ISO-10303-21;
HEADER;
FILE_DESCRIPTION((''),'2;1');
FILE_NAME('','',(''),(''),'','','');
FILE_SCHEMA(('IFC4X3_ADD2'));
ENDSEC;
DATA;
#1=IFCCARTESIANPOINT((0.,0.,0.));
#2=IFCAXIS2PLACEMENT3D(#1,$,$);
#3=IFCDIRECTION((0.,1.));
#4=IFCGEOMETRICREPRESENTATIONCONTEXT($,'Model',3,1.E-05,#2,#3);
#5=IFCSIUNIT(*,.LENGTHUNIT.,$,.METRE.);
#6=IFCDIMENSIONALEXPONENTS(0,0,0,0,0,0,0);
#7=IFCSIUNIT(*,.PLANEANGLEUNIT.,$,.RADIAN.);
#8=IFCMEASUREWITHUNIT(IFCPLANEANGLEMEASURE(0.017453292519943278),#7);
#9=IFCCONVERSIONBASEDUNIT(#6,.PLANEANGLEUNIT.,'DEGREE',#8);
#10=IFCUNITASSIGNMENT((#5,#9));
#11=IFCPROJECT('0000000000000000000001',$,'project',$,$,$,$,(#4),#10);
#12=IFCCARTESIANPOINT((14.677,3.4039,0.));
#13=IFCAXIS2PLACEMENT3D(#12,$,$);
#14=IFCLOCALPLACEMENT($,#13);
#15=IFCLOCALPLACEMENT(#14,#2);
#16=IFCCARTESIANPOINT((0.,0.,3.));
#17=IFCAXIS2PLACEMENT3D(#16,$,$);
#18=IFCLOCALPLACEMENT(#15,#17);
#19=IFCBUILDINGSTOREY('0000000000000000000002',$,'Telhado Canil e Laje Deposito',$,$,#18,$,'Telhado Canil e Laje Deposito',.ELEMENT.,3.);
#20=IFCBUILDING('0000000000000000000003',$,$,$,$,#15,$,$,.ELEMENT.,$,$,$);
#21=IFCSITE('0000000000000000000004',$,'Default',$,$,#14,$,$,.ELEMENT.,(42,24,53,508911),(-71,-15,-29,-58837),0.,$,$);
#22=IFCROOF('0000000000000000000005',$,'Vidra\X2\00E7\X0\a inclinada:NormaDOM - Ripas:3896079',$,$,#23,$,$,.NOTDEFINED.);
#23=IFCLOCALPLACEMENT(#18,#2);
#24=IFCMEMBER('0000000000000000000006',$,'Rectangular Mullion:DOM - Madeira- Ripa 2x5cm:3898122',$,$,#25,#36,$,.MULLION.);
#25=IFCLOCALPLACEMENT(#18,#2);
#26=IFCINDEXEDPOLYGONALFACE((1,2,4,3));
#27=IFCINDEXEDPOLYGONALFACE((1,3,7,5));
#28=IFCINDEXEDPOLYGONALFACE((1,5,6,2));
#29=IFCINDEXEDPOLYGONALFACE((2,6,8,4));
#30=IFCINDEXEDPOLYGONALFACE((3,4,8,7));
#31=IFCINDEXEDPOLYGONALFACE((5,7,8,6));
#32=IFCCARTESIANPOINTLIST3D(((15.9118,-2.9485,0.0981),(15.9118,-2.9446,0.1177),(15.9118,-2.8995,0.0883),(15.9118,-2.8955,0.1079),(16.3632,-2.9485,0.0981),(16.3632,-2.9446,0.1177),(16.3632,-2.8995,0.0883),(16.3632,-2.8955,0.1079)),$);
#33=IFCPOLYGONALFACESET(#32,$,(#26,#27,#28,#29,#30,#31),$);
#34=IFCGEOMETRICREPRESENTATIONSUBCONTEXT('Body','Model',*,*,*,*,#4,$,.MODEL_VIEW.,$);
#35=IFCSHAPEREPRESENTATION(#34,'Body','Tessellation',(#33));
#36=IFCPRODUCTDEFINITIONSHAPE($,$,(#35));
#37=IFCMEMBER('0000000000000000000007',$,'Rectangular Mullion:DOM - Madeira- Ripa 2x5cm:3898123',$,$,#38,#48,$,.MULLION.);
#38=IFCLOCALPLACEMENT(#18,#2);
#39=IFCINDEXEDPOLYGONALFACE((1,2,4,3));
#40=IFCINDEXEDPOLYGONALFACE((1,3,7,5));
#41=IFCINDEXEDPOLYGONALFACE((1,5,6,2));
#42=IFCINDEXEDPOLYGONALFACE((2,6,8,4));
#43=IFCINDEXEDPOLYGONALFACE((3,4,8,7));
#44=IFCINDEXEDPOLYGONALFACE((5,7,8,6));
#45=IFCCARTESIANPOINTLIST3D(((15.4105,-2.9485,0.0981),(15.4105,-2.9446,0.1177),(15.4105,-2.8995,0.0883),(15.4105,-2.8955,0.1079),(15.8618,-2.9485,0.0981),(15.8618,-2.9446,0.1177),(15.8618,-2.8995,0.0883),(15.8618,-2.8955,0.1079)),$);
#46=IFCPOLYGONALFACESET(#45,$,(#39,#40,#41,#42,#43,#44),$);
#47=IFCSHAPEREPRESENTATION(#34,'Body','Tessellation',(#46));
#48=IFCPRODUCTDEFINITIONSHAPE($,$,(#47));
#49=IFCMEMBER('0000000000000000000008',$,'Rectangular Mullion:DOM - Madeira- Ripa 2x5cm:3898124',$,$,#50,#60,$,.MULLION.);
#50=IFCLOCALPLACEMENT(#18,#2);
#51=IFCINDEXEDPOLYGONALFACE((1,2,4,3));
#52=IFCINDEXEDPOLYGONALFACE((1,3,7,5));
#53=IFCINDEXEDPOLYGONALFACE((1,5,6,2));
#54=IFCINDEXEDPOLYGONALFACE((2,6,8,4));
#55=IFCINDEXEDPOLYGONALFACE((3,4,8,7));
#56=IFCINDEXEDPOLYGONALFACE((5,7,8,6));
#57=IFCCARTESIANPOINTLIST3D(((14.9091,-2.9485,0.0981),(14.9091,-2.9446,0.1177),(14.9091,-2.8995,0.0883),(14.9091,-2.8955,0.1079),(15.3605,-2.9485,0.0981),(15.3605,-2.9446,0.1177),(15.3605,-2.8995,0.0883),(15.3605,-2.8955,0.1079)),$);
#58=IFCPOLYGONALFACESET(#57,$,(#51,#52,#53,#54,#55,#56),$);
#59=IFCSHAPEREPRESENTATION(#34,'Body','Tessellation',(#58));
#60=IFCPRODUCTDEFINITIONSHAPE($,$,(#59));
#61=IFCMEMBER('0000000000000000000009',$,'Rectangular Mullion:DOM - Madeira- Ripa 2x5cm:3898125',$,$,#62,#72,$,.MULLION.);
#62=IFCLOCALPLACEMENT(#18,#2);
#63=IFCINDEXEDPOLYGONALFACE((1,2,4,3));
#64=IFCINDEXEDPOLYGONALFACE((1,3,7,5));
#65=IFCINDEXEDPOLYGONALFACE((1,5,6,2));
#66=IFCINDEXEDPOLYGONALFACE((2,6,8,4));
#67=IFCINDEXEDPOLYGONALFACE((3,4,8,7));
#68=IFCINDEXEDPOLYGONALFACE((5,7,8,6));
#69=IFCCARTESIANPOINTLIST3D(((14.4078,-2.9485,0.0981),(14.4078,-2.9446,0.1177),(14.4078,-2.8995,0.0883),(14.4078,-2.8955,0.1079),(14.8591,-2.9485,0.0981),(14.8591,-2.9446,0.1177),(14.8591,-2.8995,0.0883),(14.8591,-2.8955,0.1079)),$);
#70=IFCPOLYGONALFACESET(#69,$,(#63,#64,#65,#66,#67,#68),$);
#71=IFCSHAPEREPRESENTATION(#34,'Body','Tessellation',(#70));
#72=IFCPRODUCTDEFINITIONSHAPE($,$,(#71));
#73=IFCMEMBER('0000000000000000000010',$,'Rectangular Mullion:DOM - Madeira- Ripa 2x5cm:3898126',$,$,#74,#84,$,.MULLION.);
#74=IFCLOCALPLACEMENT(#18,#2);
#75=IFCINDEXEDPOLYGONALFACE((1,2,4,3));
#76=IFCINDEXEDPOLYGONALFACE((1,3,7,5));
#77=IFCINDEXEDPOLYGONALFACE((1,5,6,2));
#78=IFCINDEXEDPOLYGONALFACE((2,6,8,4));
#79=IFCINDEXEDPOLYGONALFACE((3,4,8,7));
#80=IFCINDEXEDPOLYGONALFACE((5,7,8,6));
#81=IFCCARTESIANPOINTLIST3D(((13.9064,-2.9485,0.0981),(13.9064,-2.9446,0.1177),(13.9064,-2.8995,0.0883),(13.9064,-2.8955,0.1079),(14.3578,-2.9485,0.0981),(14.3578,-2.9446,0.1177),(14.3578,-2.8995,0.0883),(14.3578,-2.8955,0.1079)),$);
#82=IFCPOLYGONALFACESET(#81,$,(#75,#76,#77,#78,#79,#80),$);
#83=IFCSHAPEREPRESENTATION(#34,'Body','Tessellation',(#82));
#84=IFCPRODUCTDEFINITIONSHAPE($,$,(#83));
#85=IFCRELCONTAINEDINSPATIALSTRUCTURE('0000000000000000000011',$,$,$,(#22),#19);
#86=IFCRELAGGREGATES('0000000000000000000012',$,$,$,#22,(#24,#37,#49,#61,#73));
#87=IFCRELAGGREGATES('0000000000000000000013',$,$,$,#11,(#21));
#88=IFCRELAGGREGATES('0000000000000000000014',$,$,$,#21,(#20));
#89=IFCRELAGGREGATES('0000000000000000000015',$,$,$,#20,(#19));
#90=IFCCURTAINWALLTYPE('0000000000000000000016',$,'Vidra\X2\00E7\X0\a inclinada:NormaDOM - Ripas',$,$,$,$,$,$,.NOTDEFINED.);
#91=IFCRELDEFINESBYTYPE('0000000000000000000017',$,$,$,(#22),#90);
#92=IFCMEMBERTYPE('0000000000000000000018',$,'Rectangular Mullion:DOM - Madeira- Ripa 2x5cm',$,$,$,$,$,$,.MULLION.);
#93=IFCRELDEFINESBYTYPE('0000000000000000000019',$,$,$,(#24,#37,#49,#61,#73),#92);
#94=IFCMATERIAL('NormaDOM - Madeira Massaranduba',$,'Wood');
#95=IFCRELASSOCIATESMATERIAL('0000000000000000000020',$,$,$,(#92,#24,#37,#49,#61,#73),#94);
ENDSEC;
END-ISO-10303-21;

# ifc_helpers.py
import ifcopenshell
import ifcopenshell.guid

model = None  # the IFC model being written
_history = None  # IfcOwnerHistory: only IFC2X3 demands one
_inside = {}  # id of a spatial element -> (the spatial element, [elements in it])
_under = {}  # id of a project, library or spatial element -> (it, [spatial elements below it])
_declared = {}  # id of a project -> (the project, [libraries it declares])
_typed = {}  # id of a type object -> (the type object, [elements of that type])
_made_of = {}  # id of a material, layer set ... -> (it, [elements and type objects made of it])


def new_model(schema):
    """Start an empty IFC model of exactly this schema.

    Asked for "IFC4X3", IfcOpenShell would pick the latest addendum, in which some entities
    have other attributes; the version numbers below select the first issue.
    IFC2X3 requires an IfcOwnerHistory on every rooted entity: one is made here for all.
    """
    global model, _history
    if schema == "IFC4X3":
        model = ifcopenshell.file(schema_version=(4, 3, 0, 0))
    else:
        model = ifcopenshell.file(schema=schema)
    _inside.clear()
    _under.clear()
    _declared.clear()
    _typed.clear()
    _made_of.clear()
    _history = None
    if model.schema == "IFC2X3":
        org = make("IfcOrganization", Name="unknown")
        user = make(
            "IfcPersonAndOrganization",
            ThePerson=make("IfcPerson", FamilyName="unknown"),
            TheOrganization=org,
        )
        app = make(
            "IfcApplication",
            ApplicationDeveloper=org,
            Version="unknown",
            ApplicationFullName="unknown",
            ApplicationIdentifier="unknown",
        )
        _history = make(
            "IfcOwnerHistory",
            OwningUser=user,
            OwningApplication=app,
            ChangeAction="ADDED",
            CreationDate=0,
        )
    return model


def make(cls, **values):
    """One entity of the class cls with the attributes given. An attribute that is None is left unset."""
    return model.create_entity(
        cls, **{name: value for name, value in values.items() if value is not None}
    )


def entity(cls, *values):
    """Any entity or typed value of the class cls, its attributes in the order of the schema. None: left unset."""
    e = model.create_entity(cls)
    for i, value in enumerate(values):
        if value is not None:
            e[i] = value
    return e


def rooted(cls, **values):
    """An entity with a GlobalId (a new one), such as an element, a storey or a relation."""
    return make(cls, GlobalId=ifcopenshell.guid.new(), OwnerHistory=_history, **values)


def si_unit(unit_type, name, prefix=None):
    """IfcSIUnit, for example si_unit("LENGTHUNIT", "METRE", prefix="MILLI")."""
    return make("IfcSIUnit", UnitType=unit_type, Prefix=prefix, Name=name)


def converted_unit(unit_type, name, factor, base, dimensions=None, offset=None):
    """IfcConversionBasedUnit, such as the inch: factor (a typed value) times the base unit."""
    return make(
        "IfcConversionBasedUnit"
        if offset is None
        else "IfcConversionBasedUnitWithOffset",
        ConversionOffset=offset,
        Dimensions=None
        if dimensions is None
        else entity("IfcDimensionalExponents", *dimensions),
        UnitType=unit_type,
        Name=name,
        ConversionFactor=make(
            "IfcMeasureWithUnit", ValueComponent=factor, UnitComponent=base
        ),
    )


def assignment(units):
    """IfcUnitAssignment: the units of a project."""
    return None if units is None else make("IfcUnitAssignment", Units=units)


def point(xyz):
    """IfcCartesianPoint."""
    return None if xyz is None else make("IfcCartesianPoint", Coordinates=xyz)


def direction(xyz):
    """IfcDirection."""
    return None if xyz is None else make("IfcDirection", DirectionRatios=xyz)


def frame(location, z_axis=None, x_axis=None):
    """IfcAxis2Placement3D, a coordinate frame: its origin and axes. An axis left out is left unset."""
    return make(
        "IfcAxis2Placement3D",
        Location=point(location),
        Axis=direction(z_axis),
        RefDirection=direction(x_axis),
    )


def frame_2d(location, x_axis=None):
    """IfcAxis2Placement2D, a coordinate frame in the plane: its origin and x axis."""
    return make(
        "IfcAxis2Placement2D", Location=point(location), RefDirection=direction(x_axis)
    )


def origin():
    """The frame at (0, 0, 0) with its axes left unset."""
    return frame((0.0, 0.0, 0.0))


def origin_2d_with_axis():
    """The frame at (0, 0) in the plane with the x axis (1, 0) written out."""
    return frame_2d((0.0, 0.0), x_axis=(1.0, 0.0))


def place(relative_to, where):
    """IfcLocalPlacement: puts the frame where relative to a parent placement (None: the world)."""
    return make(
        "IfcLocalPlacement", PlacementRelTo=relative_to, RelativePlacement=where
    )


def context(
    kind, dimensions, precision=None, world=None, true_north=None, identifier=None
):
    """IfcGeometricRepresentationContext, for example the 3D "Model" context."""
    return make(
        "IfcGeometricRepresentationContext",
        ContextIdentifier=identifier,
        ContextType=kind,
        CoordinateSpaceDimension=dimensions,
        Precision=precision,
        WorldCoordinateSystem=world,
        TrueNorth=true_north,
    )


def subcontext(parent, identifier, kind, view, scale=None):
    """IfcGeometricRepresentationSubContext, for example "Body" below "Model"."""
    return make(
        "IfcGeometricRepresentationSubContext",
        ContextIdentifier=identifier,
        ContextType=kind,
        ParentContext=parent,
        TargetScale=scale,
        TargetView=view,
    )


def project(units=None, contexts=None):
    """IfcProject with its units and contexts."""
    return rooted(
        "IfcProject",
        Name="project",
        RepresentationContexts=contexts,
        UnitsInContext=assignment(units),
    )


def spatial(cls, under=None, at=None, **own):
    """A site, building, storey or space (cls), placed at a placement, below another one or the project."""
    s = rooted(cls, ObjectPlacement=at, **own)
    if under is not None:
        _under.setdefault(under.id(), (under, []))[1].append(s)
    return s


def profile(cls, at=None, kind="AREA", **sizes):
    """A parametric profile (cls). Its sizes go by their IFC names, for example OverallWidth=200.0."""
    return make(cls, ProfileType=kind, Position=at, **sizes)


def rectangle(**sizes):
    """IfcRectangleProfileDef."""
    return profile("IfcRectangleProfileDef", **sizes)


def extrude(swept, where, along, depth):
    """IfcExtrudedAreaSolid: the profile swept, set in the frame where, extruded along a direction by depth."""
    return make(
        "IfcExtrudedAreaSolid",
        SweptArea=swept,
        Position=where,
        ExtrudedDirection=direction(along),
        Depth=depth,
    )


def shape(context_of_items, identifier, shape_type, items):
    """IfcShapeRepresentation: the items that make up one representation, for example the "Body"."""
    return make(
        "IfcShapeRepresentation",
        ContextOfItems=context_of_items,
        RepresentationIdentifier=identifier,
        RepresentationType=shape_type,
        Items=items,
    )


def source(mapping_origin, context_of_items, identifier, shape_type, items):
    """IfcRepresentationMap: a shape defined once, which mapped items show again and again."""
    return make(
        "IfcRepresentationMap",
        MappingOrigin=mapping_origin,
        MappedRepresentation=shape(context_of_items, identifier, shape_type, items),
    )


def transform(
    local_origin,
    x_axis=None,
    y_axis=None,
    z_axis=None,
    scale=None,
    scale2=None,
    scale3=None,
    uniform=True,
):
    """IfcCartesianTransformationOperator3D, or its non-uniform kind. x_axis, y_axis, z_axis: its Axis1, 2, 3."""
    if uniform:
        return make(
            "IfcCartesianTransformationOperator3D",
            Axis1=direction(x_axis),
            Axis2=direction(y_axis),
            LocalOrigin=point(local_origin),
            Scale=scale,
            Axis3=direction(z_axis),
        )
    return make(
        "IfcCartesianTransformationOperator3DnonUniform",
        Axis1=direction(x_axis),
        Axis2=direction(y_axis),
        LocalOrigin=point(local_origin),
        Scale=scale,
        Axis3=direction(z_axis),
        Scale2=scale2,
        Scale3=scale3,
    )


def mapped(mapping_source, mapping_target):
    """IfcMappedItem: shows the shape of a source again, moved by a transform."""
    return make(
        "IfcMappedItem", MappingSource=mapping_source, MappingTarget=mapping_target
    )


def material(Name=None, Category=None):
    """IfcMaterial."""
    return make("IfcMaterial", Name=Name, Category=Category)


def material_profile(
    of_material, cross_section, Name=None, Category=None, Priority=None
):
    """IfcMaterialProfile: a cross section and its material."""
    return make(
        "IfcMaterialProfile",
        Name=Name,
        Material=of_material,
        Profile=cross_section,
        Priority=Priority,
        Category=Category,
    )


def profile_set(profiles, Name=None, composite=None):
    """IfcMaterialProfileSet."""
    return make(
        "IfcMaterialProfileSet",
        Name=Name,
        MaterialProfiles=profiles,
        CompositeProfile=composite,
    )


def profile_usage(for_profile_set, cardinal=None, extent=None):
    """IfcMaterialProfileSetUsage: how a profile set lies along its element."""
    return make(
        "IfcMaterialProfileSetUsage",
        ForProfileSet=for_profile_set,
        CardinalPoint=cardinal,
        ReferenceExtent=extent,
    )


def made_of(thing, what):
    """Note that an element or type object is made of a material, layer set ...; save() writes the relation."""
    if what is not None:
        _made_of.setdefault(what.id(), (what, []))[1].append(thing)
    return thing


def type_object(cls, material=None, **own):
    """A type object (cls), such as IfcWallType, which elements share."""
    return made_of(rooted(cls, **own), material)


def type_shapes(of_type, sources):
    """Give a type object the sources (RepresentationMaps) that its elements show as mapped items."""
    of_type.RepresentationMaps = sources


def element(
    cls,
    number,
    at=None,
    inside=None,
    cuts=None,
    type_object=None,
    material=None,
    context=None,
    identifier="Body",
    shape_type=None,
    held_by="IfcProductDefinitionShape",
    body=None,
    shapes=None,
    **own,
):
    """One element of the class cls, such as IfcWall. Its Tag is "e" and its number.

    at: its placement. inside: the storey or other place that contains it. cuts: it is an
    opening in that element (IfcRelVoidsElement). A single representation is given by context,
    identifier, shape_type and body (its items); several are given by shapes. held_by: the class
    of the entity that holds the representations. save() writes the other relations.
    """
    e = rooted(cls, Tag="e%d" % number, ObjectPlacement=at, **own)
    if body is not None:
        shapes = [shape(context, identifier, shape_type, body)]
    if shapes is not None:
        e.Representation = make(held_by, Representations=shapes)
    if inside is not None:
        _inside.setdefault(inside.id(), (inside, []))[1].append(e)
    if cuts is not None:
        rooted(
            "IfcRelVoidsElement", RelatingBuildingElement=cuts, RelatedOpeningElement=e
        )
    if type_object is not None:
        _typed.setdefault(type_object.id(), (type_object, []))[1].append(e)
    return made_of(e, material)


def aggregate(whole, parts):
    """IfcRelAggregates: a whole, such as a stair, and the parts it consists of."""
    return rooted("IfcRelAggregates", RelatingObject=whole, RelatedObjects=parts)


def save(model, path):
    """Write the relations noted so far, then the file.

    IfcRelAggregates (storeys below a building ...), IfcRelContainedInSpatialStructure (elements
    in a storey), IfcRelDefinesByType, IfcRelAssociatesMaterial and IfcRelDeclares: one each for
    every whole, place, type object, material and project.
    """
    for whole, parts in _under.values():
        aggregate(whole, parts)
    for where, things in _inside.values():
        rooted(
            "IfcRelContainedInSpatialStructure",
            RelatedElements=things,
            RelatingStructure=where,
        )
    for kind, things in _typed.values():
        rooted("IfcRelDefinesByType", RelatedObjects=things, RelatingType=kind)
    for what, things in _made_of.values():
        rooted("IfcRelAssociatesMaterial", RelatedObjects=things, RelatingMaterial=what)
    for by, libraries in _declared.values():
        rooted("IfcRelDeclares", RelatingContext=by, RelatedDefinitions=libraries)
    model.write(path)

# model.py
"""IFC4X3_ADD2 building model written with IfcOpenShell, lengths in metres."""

from ifc_helpers import new_model, entity, si_unit, converted_unit, direction, frame, origin, origin_2d_with_axis, place, context, subcontext, project, spatial, rectangle, extrude, source, transform, mapped, material, material_profile, profile_set, profile_usage, type_object, type_shapes, element, aggregate, save


model = new_model("IFC4X3_ADD2")

# Units and contexts
model_context = context("Model", 3, precision=1e-05, world=origin(), true_north=direction((0.0, 1.0)))
body_context = subcontext(model_context, "Body", "Model", "MODEL_VIEW")
ifc_project = project(units=[si_unit("LENGTHUNIT", "METRE"), converted_unit("PLANEANGLEUNIT", "DEGREE", entity("IfcPlaneAngleMeasure", 0.017453292519943278), si_unit("PLANEANGLEUNIT", "RADIAN"), dimensions=[0, 0, 0, 0, 0, 0, 0])], contexts=[model_context])

# Site, building, storey
site_placement = place(None, frame((14.677, 3.4039, 0.0)))
site = spatial("IfcSite", under=ifc_project, at=site_placement, Name="Default", CompositionType="ELEMENT", RefLatitude=(42, 24, 53, 508911), RefLongitude=(-71, -15, -29, -58837), RefElevation=0.0)
building_placement = place(site_placement, origin())
building = spatial("IfcBuilding", under=site, at=building_placement, CompositionType="ELEMENT")
storey_placement = place(building_placement, frame((0.0, 0.0, 3.0)))
storey = spatial("IfcBuildingStorey", under=building, at=storey_placement, Name="Telhado Canil e Laje Deposito", LongName="Telhado Canil e Laje Deposito", CompositionType="ELEMENT", Elevation=3.0)

# Roof
curtain_wall_type_1 = type_object("IfcCurtainWallType", Name="Vidraça inclinada:NormaDOM - Ripas", PredefinedType="NOTDEFINED")
roof_1_placement = place(storey_placement, frame((0.0, 0.0, -3.0)))
roof_1 = element("IfcRoof", 1, at=roof_1_placement, inside=storey, type_object=curtain_wall_type_1, Name="Vidraça inclinada:NormaDOM - Ripas:3896079", PredefinedType="NOTDEFINED")
ifc_material = material(Name="NormaDOM - Madeira Massaranduba", Category="Wood")

# Members
ifc_material_profile_1 = material_profile(ifc_material, rectangle(XDim=0.05, YDim=0.02, at=origin_2d_with_axis()), Name="DOM - Madeira- Ripa 2x5cm")
ifc_profile_set_1 = profile_set([ifc_material_profile_1], Name="DOM - Madeira- Ripa 2x5cm")
ifc_profile_usage_1 = profile_usage(ifc_profile_set_1)
member_type_1 = type_object("IfcMemberType", Name="Rectangular Mullion:DOM - Madeira- Ripa 2x5cm", PredefinedType="MULLION", material=ifc_profile_set_1)
shared_shape_1 = source(origin(), body_context, "Body", "SweptSolid", [
    extrude(rectangle(XDim=0.05, YDim=0.02, at=origin_2d_with_axis()), frame((0.025, 0.01, -0.4514), z_axis=(0.0, 0.0, 1.0), x_axis=(-1.0, 0.0, 0.0)), (0.0, 0.0, 1.0), 0.4514),
])
type_shapes(member_type_1, [shared_shape_1])
member_1_placement = place(roof_1_placement, frame((16.3632, -2.8955, 3.1079), z_axis=(1.0, 0.0, 0.0), x_axis=(0.0, -0.980581, 0.196116)))
member_1 = element("IfcMember", 2, at=member_1_placement, type_object=member_type_1, material=ifc_profile_usage_1, Name="Rectangular Mullion:DOM - Madeira- Ripa 2x5cm:3898122", PredefinedType="MULLION", context=body_context, shape_type="MappedRepresentation", body=[
    mapped(shared_shape_1, transform((0.0, 0.0, 0.0), scale=1.0)),
])
member_2_placement = place(roof_1_placement, frame((15.8618, -2.8955, 3.1079), z_axis=(1.0, 0.0, 0.0), x_axis=(0.0, -0.980581, 0.196116)))
member_2 = element("IfcMember", 3, at=member_2_placement, type_object=member_type_1, material=ifc_profile_usage_1, Name="Rectangular Mullion:DOM - Madeira- Ripa 2x5cm:3898123", PredefinedType="MULLION", context=body_context, shape_type="MappedRepresentation", body=[
    mapped(shared_shape_1, transform((0.0, 0.0, 0.0), scale=1.0)),
])
member_3_placement = place(roof_1_placement, frame((15.3605, -2.8955, 3.1079), z_axis=(1.0, 0.0, 0.0), x_axis=(0.0, -0.980581, 0.196116)))
member_3 = element("IfcMember", 4, at=member_3_placement, type_object=member_type_1, material=ifc_profile_usage_1, Name="Rectangular Mullion:DOM - Madeira- Ripa 2x5cm:3898124", PredefinedType="MULLION", context=body_context, shape_type="MappedRepresentation", body=[
    mapped(shared_shape_1, transform((0.0, 0.0, 0.0), scale=1.0)),
])
member_4_placement = place(roof_1_placement, frame((14.8591, -2.8955, 3.1079), z_axis=(1.0, 0.0, 0.0), x_axis=(0.0, -0.980581, 0.196116)))
member_4 = element("IfcMember", 5, at=member_4_placement, type_object=member_type_1, material=ifc_profile_usage_1, Name="Rectangular Mullion:DOM - Madeira- Ripa 2x5cm:3898125", PredefinedType="MULLION", context=body_context, shape_type="MappedRepresentation", body=[
    mapped(shared_shape_1, transform((0.0, 0.0, 0.0), scale=1.0)),
])
member_5_placement = place(roof_1_placement, frame((14.3578, -2.8955, 3.1079), z_axis=(1.0, 0.0, 0.0), x_axis=(0.0, -0.980581, 0.196116)))
member_5 = element("IfcMember", 6, at=member_5_placement, type_object=member_type_1, material=ifc_profile_usage_1, Name="Rectangular Mullion:DOM - Madeira- Ripa 2x5cm:3898126", PredefinedType="MULLION", context=body_context, shape_type="MappedRepresentation", body=[
    mapped(shared_shape_1, transform((0.0, 0.0, 0.0), scale=1.0)),
])
aggregate(roof_1, [member_1, member_2, member_3, member_4, member_5])

save(model, "model.ifc")
